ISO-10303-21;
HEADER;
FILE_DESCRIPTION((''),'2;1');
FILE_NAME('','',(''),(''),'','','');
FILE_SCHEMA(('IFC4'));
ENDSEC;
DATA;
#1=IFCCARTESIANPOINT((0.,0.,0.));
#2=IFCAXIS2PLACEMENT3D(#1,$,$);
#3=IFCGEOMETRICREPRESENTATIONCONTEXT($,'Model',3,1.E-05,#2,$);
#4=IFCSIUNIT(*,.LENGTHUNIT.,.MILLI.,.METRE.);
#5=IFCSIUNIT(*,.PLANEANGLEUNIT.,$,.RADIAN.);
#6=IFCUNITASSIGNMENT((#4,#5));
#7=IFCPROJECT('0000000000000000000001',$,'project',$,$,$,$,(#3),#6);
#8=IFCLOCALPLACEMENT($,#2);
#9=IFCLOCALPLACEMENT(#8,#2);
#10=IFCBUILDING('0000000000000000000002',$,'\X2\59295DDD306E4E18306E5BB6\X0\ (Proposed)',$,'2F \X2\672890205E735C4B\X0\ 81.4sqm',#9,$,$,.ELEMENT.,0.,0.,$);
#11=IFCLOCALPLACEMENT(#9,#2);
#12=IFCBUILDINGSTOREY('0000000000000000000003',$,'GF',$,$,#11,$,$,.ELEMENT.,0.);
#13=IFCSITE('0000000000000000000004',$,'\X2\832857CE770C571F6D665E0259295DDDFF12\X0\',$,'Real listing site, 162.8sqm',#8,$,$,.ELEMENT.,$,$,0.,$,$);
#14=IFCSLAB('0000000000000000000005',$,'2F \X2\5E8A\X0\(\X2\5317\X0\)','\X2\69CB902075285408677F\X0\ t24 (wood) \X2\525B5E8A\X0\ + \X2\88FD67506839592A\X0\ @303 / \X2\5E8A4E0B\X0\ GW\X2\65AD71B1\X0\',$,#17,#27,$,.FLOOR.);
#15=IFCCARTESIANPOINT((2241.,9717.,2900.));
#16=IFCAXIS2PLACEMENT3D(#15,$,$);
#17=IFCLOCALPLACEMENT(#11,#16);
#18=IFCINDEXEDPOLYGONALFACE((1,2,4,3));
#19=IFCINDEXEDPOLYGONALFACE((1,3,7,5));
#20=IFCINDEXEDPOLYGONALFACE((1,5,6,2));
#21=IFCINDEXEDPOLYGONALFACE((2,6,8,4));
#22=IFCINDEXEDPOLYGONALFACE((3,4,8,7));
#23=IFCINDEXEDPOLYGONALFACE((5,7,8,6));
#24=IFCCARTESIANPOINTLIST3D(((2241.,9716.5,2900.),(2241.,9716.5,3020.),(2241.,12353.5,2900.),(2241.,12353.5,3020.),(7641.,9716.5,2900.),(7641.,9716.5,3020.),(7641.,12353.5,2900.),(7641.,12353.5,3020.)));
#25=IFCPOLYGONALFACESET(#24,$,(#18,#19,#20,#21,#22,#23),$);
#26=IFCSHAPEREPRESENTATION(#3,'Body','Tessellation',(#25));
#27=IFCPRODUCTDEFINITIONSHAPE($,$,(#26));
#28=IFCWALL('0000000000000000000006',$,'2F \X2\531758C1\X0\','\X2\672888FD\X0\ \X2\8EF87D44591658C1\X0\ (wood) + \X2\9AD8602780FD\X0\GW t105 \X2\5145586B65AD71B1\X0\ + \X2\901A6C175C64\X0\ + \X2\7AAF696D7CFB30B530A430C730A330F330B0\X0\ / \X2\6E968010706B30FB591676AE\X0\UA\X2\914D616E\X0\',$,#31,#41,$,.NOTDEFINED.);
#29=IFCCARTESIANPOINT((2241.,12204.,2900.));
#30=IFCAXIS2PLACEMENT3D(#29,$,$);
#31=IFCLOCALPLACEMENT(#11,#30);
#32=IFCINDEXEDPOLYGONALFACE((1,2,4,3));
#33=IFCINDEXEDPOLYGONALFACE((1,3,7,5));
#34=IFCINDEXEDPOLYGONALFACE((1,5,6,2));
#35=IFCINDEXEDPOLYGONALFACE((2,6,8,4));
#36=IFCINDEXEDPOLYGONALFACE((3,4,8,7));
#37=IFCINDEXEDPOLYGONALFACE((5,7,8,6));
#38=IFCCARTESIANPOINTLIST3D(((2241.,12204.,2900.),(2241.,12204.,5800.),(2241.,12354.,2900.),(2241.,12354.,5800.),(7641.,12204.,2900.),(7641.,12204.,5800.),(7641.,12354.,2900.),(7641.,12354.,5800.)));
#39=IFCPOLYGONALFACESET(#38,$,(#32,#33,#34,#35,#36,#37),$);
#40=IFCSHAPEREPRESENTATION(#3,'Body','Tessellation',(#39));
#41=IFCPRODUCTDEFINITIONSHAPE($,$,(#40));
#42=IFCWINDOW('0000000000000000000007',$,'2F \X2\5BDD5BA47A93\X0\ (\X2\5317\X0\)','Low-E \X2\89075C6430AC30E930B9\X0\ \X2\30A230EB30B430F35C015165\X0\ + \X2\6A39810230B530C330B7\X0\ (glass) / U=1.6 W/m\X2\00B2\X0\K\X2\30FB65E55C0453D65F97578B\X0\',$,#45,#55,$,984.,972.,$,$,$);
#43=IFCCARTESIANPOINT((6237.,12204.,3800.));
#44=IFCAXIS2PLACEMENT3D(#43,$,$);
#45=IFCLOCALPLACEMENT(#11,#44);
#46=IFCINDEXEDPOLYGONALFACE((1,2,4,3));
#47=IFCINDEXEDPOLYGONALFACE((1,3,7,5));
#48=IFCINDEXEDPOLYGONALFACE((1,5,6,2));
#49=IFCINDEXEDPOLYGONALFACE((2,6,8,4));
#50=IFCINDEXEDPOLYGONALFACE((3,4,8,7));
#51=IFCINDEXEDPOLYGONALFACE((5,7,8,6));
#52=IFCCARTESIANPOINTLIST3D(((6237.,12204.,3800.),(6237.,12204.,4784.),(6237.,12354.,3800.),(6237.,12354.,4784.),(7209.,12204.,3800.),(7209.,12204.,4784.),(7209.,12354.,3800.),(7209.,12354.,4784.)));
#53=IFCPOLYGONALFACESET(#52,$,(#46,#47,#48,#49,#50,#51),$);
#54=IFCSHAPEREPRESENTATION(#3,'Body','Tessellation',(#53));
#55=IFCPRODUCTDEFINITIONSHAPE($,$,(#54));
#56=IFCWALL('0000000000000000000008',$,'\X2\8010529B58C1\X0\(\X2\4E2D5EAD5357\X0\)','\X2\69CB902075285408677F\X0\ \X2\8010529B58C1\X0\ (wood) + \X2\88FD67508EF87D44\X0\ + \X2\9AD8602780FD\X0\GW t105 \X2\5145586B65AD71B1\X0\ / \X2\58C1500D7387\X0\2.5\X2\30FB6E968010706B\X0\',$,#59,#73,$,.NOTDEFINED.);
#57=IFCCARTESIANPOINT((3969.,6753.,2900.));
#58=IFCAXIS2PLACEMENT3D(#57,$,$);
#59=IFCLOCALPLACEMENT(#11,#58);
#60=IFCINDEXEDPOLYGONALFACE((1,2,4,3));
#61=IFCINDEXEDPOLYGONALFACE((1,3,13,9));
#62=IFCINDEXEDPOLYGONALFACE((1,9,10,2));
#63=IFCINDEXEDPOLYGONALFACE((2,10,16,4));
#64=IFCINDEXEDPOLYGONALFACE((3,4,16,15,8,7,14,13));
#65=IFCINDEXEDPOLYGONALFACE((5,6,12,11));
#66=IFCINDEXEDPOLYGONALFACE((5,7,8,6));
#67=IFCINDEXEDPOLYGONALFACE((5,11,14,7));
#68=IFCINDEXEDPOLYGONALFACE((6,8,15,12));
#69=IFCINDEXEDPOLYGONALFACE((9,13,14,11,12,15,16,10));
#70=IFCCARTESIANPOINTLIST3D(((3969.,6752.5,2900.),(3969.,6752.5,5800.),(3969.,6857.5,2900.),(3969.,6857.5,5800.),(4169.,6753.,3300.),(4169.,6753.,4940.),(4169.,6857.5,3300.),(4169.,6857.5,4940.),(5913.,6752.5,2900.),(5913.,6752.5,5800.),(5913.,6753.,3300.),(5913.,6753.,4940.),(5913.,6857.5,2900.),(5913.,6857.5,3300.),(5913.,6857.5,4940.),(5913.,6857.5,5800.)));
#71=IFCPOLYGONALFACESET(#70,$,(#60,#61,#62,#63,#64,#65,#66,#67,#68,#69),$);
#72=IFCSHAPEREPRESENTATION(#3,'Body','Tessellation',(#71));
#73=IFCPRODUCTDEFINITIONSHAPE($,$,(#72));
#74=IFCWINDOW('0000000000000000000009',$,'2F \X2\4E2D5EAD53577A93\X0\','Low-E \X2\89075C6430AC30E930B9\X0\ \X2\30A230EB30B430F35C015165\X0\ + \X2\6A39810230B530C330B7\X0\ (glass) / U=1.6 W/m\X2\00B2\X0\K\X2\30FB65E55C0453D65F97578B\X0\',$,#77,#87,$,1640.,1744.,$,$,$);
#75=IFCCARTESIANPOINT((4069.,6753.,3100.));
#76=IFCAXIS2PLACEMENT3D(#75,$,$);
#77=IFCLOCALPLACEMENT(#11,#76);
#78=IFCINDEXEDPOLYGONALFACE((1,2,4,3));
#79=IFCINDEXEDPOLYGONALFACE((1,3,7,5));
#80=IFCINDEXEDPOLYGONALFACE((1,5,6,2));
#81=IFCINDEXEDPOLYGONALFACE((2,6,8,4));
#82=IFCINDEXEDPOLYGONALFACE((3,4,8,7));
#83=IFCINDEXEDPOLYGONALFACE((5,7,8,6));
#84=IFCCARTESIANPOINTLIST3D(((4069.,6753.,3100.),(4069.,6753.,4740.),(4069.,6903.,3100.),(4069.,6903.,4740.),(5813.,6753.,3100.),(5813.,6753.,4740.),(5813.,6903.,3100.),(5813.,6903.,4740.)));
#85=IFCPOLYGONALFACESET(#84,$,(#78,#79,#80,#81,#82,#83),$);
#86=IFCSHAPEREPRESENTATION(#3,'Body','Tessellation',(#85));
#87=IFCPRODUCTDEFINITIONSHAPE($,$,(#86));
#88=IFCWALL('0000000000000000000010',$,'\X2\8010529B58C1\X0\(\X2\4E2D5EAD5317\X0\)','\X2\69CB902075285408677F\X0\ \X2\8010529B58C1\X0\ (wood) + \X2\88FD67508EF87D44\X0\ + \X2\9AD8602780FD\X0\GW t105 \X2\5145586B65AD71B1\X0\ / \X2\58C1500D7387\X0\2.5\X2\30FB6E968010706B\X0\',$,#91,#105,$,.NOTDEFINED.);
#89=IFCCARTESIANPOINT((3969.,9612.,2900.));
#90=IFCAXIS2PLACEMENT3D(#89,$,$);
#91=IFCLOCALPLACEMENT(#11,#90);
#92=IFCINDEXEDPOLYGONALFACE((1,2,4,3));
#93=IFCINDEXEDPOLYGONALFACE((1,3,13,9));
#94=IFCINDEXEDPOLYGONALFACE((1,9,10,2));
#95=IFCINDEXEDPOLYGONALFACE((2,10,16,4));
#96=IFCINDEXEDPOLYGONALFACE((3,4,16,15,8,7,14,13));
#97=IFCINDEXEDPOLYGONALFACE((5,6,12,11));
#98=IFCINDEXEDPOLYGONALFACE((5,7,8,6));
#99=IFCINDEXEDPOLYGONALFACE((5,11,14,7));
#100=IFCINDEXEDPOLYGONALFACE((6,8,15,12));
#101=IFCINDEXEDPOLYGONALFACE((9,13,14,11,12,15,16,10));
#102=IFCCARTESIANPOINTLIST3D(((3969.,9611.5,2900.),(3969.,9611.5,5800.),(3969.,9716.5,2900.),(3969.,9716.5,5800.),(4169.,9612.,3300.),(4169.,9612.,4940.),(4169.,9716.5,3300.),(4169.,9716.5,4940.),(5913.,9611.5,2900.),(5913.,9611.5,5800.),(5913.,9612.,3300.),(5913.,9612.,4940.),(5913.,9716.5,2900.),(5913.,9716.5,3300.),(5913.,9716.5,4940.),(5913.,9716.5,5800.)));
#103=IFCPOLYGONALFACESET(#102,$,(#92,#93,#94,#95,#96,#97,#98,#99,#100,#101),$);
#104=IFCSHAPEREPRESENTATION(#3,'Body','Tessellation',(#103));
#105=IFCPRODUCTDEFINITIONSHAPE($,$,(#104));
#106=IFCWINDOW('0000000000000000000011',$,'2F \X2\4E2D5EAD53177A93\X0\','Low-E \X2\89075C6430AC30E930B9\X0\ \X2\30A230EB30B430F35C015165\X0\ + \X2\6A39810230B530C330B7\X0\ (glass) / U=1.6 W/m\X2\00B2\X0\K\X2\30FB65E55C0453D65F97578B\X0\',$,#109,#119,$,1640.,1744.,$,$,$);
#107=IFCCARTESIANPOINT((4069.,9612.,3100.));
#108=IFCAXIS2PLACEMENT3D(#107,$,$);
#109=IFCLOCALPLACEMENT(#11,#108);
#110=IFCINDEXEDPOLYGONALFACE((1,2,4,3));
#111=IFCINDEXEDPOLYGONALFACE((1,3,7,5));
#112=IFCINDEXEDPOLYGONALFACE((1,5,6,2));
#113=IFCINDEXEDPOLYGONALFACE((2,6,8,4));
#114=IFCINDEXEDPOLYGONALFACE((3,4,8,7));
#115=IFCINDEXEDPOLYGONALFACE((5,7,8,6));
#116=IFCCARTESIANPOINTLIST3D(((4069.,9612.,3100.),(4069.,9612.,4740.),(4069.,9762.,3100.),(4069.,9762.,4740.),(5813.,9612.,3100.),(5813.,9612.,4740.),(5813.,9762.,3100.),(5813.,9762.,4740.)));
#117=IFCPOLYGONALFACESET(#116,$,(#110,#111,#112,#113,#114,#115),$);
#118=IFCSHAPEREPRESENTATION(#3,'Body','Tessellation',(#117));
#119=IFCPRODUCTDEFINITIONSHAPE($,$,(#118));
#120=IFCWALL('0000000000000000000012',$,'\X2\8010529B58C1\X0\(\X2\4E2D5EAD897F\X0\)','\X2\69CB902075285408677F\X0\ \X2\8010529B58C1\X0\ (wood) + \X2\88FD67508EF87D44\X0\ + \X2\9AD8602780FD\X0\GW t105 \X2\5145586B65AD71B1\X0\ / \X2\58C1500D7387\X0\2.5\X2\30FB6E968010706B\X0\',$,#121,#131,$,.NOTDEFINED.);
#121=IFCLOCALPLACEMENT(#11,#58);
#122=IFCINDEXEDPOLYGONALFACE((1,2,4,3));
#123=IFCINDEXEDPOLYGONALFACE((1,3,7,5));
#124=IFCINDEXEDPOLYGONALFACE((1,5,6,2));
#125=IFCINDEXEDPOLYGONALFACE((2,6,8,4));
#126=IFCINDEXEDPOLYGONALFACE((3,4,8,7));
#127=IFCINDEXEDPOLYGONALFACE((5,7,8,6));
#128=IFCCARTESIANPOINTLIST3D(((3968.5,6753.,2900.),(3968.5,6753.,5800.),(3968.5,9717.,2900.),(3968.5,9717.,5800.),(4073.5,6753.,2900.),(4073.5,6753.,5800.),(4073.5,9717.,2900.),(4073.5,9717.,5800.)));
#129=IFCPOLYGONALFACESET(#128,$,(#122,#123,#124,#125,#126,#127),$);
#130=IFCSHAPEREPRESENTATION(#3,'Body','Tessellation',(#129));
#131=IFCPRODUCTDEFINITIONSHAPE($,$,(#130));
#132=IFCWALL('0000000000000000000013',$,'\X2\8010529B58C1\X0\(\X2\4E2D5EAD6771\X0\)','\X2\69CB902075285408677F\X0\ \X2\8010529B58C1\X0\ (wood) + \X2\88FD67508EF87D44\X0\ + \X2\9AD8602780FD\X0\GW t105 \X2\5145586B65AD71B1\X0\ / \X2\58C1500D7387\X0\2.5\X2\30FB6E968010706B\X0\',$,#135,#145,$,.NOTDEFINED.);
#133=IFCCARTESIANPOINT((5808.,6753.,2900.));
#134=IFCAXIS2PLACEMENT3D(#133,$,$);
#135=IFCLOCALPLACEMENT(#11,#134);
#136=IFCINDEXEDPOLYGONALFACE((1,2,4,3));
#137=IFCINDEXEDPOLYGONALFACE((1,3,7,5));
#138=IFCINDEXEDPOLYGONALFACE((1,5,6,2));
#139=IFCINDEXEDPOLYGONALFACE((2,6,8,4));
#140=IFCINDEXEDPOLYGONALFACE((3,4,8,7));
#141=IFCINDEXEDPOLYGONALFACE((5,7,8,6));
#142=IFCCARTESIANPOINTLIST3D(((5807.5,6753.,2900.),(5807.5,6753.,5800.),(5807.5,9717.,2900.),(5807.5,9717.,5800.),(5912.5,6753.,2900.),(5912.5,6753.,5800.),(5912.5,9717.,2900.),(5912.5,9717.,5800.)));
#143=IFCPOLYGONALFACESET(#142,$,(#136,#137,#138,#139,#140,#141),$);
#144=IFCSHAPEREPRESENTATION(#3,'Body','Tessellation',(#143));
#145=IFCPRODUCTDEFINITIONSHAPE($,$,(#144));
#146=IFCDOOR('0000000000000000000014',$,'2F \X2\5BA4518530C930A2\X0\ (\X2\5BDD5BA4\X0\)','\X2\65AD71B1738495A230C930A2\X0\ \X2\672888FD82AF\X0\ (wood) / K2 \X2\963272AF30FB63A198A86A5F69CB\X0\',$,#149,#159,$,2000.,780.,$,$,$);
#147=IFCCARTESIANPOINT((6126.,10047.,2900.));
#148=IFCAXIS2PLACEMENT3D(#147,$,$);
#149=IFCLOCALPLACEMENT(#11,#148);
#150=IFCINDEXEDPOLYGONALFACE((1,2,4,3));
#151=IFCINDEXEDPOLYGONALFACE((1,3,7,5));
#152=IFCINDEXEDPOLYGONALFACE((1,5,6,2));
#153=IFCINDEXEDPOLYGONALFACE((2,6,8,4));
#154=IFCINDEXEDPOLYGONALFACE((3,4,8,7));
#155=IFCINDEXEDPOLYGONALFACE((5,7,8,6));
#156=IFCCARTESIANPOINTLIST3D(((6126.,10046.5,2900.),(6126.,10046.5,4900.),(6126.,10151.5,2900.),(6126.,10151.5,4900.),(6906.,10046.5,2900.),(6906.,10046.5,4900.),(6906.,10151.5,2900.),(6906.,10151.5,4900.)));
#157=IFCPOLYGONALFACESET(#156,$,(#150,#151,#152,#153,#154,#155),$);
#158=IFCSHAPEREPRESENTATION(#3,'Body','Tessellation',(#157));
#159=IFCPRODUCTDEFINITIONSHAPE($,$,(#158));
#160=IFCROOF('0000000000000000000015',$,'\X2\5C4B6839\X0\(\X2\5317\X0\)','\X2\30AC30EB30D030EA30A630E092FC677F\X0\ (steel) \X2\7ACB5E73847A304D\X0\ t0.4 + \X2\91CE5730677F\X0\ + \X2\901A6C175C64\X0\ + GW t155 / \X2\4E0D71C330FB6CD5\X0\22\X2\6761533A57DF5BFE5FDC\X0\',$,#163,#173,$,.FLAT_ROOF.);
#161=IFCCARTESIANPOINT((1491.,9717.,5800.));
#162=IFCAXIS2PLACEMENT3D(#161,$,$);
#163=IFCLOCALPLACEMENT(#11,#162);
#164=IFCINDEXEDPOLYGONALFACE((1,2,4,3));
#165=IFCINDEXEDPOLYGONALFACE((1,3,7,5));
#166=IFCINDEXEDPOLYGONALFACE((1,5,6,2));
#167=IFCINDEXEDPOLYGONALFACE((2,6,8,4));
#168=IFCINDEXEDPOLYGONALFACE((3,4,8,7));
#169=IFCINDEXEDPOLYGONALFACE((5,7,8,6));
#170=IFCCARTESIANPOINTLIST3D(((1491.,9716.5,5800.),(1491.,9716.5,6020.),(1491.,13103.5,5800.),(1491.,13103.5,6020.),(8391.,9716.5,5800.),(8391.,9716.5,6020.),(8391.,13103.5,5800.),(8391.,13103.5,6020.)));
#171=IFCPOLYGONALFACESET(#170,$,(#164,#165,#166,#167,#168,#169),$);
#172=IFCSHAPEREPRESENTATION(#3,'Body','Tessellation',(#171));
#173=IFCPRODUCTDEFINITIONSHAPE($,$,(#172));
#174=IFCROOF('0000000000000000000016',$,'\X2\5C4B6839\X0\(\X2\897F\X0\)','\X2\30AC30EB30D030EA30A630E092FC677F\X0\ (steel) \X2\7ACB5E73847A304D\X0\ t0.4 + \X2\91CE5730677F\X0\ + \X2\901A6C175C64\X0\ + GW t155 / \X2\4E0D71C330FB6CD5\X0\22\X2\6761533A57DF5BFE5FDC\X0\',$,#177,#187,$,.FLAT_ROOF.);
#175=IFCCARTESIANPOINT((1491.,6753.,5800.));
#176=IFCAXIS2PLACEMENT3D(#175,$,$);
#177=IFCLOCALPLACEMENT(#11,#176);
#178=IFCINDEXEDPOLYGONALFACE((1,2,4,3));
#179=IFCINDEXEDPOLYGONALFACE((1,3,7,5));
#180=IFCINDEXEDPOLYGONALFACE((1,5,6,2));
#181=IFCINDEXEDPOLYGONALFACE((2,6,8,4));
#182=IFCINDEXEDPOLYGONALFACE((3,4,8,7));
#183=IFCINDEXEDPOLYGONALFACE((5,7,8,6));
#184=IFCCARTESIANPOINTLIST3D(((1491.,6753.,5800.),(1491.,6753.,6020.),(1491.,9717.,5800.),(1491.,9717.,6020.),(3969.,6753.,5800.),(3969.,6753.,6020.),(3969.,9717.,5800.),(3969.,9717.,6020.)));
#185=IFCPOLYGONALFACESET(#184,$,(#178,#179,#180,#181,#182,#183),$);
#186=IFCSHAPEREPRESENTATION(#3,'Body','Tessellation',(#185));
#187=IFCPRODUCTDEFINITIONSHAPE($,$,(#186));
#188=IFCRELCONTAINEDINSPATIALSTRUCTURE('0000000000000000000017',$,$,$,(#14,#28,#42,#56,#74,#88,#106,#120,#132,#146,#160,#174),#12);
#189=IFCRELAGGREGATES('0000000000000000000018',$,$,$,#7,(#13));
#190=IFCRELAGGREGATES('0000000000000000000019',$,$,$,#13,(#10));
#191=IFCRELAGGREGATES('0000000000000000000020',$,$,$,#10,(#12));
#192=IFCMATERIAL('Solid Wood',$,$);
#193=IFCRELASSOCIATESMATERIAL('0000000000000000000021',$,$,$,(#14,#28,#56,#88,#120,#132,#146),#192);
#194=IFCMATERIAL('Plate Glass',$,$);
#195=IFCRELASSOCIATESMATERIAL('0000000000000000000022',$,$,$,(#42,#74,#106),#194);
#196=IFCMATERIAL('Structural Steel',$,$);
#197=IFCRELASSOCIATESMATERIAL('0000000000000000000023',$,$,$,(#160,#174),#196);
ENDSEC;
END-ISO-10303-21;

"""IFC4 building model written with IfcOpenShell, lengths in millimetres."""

from ifc_helpers import new_model, si_unit, frame, frame_2d, origin, place, context, project, spatial, rectangle, extrude, material, element, fill, save


model = new_model("IFC4")

# Units and contexts
model_context = context("Model", 3, precision=1e-05, world=origin())
ifc_project = project(units=[si_unit("LENGTHUNIT", "METRE", prefix="MILLI"), si_unit("PLANEANGLEUNIT", "RADIAN")], contexts=[model_context])

# Site, building, storey
site_placement = place(None, origin())
site = spatial("IfcSite", under=ifc_project, at=site_placement, Name="茨城県土浦市天川２", ObjectType="Real listing site, 162.8sqm", CompositionType="ELEMENT", RefElevation=0.0)
building_placement = place(site_placement, origin())
building = spatial("IfcBuilding", under=site, at=building_placement, Name="天川の丘の家 (Proposed)", ObjectType="2F 木造平屋 81.4sqm", CompositionType="ELEMENT", ElevationOfRefHeight=0.0, ElevationOfTerrain=0.0)
storey_placement = place(building_placement, origin())
storey = spatial("IfcBuildingStorey", under=building, at=storey_placement, Name="GF", CompositionType="ELEMENT", Elevation=0.0)

# Slab
ifc_material_1 = material(Name="Solid Wood")
slab_placement = place(storey_placement, frame((2241.0, 9717.0, 2900.0)))
element("IfcSlab", 1, at=slab_placement, inside=storey, material=ifc_material_1, Name="2F 床(北)", Description="構造用合板 t24 (wood) 剛床 + 製材根太 @303 / 床下 GW断熱", PredefinedType="FLOOR", context=model_context, shape_type="SweptSolid", body=[
    extrude(rectangle(XDim=5400.0, YDim=2637.0, at=frame_2d((2700.0, 1318.0))), frame((2241.0, 9717.0, 2900.0)), (0.0, 0.0, 1.0), 120.0),
])

# Walls, openings, windows
wall_1_placement = place(storey_placement, frame((2241.0, 12204.0, 2900.0)))
wall_1 = element("IfcWall", 2, at=wall_1_placement, inside=storey, material=ifc_material_1, Name="2F 北壁", Description="木製 軸組外壁 (wood) + 高性能GW t105 充填断熱 + 通気層 + 窯業系サイディング / 準耐火・外皮UA配慮", PredefinedType="NOTDEFINED", context=model_context, shape_type="SweptSolid", body=[
    extrude(rectangle(XDim=5400.0, YDim=150.0, at=frame_2d((2700.0, 75.0))), frame((2241.0, 12204.0, 2900.0)), (0.0, 0.0, 1.0), 2900.0),
])
opening_1_placement = place(storey_placement, frame((6237.0, 12204.0, 3800.0)))
opening_1 = element("IfcOpeningElement", 3, at=opening_1_placement, cuts=wall_1, PredefinedType="NOTDEFINED", context=model_context, shape_type="SweptSolid", body=[
    extrude(rectangle(XDim=972.0, YDim=150.0, at=frame_2d((486.0, 75.0))), frame((6237.0, 12204.0, 3800.0)), (0.0, 0.0, 1.0), 984.0),
])
ifc_material_2 = material(Name="Plate Glass")
window_1_placement = place(storey_placement, frame((6237.0, 12204.0, 3800.0)))
window_1 = element("IfcWindow", 4, at=window_1_placement, inside=storey, material=ifc_material_2, Name="2F 寝室窓 (北)", Description="Low-E 複層ガラス アルゴン封入 + 樹脂サッシ (glass) / U=1.6 W/m²K・日射取得型", OverallHeight=984.0, OverallWidth=972.0, context=model_context, shape_type="SweptSolid", body=[
    extrude(rectangle(XDim=972.0, YDim=150.0, at=frame_2d((486.0, 75.0))), frame((6237.0, 12204.0, 3800.0)), (0.0, 0.0, 1.0), 984.0),
])
fill(opening_1, window_1)
wall_2_placement = place(storey_placement, frame((3969.0, 6753.0, 2900.0)))
wall_2 = element("IfcWall", 5, at=wall_2_placement, inside=storey, material=ifc_material_1, Name="耐力壁(中庭南)", Description="構造用合板 耐力壁 (wood) + 製材軸組 + 高性能GW t105 充填断熱 / 壁倍率2.5・準耐火", PredefinedType="NOTDEFINED", context=model_context, shape_type="SweptSolid", body=[
    extrude(rectangle(XDim=1944.0, YDim=105.0, at=frame_2d((972.0, 52.0))), frame((3969.0, 6753.0, 2900.0)), (0.0, 0.0, 1.0), 2900.0),
])
opening_2_placement = place(storey_placement, frame((4069.0, 6753.0, 3100.0)))
opening_2 = element("IfcOpeningElement", 6, at=opening_2_placement, cuts=wall_2, PredefinedType="NOTDEFINED", context=model_context, shape_type="SweptSolid", body=[
    extrude(rectangle(XDim=1744.0, YDim=150.0, at=frame_2d((872.0, 75.0))), frame((4069.0, 6753.0, 3100.0)), (0.0, 0.0, 1.0), 1640.0),
])
window_2_placement = place(storey_placement, frame((4069.0, 6753.0, 3100.0)))
window_2 = element("IfcWindow", 7, at=window_2_placement, inside=storey, material=ifc_material_2, Name="2F 中庭南窓", Description="Low-E 複層ガラス アルゴン封入 + 樹脂サッシ (glass) / U=1.6 W/m²K・日射取得型", OverallHeight=1640.0, OverallWidth=1744.0, context=model_context, shape_type="SweptSolid", body=[
    extrude(rectangle(XDim=1744.0, YDim=150.0, at=frame_2d((872.0, 75.0))), frame((4069.0, 6753.0, 3100.0)), (0.0, 0.0, 1.0), 1640.0),
])
fill(opening_2, window_2)
wall_3_placement = place(storey_placement, frame((3969.0, 9612.0, 2900.0)))
wall_3 = element("IfcWall", 8, at=wall_3_placement, inside=storey, material=ifc_material_1, Name="耐力壁(中庭北)", Description="構造用合板 耐力壁 (wood) + 製材軸組 + 高性能GW t105 充填断熱 / 壁倍率2.5・準耐火", PredefinedType="NOTDEFINED", context=model_context, shape_type="SweptSolid", body=[
    extrude(rectangle(XDim=1944.0, YDim=105.0, at=frame_2d((972.0, 52.0))), frame((3969.0, 9612.0, 2900.0)), (0.0, 0.0, 1.0), 2900.0),
])
opening_3_placement = place(storey_placement, frame((4069.0, 9612.0, 3100.0)))
opening_3 = element("IfcOpeningElement", 9, at=opening_3_placement, cuts=wall_3, PredefinedType="NOTDEFINED", context=model_context, shape_type="SweptSolid", body=[
    extrude(rectangle(XDim=1744.0, YDim=150.0, at=frame_2d((872.0, 75.0))), frame((4069.0, 9612.0, 3100.0)), (0.0, 0.0, 1.0), 1640.0),
])
window_3_placement = place(storey_placement, frame((4069.0, 9612.0, 3100.0)))
window_3 = element("IfcWindow", 10, at=window_3_placement, inside=storey, material=ifc_material_2, Name="2F 中庭北窓", Description="Low-E 複層ガラス アルゴン封入 + 樹脂サッシ (glass) / U=1.6 W/m²K・日射取得型", OverallHeight=1640.0, OverallWidth=1744.0, context=model_context, shape_type="SweptSolid", body=[
    extrude(rectangle(XDim=1744.0, YDim=150.0, at=frame_2d((872.0, 75.0))), frame((4069.0, 9612.0, 3100.0)), (0.0, 0.0, 1.0), 1640.0),
])
fill(opening_3, window_3)

# Walls
wall_4_placement = place(storey_placement, frame((3969.0, 6753.0, 2900.0)))
element("IfcWall", 11, at=wall_4_placement, inside=storey, material=ifc_material_1, Name="耐力壁(中庭西)", Description="構造用合板 耐力壁 (wood) + 製材軸組 + 高性能GW t105 充填断熱 / 壁倍率2.5・準耐火", PredefinedType="NOTDEFINED", context=model_context, shape_type="SweptSolid", body=[
    extrude(rectangle(XDim=105.0, YDim=2964.0, at=frame_2d((52.0, 1482.0))), frame((3969.0, 6753.0, 2900.0)), (0.0, 0.0, 1.0), 2900.0),
])
wall_5_placement = place(storey_placement, frame((5808.0, 6753.0, 2900.0)))
element("IfcWall", 12, at=wall_5_placement, inside=storey, material=ifc_material_1, Name="耐力壁(中庭東)", Description="構造用合板 耐力壁 (wood) + 製材軸組 + 高性能GW t105 充填断熱 / 壁倍率2.5・準耐火", PredefinedType="NOTDEFINED", context=model_context, shape_type="SweptSolid", body=[
    extrude(rectangle(XDim=105.0, YDim=2964.0, at=frame_2d((52.0, 1482.0))), frame((5808.0, 6753.0, 2900.0)), (0.0, 0.0, 1.0), 2900.0),
])

# Door
door_placement = place(storey_placement, frame((6126.0, 10047.0, 2900.0)))
element("IfcDoor", 13, at=door_placement, inside=storey, material=ifc_material_1, Name="2F 室内ドア (寝室)", Description="断熱玄関ドア 木製芯 (wood) / K2 防犯・採風機構", OverallHeight=2000.0, OverallWidth=780.0, context=model_context, shape_type="SweptSolid", body=[
    extrude(rectangle(XDim=780.0, YDim=105.0, at=frame_2d((390.0, 52.0))), frame((6126.0, 10047.0, 2900.0)), (0.0, 0.0, 1.0), 2000.0),
])

# Roofs
ifc_material_3 = material(Name="Structural Steel")
for number, where, name in (
    (14, (1491.0, 9717.0, 5800.0), "屋根(北)"),
):
    element("IfcRoof", number, at=place(storey_placement, frame(where)), inside=storey, material=ifc_material_3, Name=name, Description="ガルバリウム鋼板 (steel) 立平葺き t0.4 + 野地板 + 通気層 + GW t155 / 不燃・法22条区域対応", PredefinedType="FLAT_ROOF", context=model_context, shape_type="SweptSolid", body=[
        extrude(rectangle(XDim=6900.0, YDim=3387.0, at=frame_2d((3450.0, 1693.0))), frame((1491.0, 9717.0, 5800.0)), (0.0, 0.0, 1.0), 220.0),
    ])
roof_1_placement = place(storey_placement, frame((1491.0, 6753.0, 5800.0)))
element("IfcRoof", 15, at=roof_1_placement, inside=storey, material=ifc_material_3, Name="屋根(西)", Description="ガルバリウム鋼板 (steel) 立平葺き t0.4 + 野地板 + 通気層 + GW t155 / 不燃・法22条区域対応", PredefinedType="FLAT_ROOF", context=model_context, shape_type="SweptSolid", body=[
    extrude(rectangle(XDim=2478.0, YDim=2964.0, at=frame_2d((1239.0, 1482.0))), frame((1491.0, 6753.0, 5800.0)), (0.0, 0.0, 1.0), 220.0),
])

save(model, "model.ifc")
